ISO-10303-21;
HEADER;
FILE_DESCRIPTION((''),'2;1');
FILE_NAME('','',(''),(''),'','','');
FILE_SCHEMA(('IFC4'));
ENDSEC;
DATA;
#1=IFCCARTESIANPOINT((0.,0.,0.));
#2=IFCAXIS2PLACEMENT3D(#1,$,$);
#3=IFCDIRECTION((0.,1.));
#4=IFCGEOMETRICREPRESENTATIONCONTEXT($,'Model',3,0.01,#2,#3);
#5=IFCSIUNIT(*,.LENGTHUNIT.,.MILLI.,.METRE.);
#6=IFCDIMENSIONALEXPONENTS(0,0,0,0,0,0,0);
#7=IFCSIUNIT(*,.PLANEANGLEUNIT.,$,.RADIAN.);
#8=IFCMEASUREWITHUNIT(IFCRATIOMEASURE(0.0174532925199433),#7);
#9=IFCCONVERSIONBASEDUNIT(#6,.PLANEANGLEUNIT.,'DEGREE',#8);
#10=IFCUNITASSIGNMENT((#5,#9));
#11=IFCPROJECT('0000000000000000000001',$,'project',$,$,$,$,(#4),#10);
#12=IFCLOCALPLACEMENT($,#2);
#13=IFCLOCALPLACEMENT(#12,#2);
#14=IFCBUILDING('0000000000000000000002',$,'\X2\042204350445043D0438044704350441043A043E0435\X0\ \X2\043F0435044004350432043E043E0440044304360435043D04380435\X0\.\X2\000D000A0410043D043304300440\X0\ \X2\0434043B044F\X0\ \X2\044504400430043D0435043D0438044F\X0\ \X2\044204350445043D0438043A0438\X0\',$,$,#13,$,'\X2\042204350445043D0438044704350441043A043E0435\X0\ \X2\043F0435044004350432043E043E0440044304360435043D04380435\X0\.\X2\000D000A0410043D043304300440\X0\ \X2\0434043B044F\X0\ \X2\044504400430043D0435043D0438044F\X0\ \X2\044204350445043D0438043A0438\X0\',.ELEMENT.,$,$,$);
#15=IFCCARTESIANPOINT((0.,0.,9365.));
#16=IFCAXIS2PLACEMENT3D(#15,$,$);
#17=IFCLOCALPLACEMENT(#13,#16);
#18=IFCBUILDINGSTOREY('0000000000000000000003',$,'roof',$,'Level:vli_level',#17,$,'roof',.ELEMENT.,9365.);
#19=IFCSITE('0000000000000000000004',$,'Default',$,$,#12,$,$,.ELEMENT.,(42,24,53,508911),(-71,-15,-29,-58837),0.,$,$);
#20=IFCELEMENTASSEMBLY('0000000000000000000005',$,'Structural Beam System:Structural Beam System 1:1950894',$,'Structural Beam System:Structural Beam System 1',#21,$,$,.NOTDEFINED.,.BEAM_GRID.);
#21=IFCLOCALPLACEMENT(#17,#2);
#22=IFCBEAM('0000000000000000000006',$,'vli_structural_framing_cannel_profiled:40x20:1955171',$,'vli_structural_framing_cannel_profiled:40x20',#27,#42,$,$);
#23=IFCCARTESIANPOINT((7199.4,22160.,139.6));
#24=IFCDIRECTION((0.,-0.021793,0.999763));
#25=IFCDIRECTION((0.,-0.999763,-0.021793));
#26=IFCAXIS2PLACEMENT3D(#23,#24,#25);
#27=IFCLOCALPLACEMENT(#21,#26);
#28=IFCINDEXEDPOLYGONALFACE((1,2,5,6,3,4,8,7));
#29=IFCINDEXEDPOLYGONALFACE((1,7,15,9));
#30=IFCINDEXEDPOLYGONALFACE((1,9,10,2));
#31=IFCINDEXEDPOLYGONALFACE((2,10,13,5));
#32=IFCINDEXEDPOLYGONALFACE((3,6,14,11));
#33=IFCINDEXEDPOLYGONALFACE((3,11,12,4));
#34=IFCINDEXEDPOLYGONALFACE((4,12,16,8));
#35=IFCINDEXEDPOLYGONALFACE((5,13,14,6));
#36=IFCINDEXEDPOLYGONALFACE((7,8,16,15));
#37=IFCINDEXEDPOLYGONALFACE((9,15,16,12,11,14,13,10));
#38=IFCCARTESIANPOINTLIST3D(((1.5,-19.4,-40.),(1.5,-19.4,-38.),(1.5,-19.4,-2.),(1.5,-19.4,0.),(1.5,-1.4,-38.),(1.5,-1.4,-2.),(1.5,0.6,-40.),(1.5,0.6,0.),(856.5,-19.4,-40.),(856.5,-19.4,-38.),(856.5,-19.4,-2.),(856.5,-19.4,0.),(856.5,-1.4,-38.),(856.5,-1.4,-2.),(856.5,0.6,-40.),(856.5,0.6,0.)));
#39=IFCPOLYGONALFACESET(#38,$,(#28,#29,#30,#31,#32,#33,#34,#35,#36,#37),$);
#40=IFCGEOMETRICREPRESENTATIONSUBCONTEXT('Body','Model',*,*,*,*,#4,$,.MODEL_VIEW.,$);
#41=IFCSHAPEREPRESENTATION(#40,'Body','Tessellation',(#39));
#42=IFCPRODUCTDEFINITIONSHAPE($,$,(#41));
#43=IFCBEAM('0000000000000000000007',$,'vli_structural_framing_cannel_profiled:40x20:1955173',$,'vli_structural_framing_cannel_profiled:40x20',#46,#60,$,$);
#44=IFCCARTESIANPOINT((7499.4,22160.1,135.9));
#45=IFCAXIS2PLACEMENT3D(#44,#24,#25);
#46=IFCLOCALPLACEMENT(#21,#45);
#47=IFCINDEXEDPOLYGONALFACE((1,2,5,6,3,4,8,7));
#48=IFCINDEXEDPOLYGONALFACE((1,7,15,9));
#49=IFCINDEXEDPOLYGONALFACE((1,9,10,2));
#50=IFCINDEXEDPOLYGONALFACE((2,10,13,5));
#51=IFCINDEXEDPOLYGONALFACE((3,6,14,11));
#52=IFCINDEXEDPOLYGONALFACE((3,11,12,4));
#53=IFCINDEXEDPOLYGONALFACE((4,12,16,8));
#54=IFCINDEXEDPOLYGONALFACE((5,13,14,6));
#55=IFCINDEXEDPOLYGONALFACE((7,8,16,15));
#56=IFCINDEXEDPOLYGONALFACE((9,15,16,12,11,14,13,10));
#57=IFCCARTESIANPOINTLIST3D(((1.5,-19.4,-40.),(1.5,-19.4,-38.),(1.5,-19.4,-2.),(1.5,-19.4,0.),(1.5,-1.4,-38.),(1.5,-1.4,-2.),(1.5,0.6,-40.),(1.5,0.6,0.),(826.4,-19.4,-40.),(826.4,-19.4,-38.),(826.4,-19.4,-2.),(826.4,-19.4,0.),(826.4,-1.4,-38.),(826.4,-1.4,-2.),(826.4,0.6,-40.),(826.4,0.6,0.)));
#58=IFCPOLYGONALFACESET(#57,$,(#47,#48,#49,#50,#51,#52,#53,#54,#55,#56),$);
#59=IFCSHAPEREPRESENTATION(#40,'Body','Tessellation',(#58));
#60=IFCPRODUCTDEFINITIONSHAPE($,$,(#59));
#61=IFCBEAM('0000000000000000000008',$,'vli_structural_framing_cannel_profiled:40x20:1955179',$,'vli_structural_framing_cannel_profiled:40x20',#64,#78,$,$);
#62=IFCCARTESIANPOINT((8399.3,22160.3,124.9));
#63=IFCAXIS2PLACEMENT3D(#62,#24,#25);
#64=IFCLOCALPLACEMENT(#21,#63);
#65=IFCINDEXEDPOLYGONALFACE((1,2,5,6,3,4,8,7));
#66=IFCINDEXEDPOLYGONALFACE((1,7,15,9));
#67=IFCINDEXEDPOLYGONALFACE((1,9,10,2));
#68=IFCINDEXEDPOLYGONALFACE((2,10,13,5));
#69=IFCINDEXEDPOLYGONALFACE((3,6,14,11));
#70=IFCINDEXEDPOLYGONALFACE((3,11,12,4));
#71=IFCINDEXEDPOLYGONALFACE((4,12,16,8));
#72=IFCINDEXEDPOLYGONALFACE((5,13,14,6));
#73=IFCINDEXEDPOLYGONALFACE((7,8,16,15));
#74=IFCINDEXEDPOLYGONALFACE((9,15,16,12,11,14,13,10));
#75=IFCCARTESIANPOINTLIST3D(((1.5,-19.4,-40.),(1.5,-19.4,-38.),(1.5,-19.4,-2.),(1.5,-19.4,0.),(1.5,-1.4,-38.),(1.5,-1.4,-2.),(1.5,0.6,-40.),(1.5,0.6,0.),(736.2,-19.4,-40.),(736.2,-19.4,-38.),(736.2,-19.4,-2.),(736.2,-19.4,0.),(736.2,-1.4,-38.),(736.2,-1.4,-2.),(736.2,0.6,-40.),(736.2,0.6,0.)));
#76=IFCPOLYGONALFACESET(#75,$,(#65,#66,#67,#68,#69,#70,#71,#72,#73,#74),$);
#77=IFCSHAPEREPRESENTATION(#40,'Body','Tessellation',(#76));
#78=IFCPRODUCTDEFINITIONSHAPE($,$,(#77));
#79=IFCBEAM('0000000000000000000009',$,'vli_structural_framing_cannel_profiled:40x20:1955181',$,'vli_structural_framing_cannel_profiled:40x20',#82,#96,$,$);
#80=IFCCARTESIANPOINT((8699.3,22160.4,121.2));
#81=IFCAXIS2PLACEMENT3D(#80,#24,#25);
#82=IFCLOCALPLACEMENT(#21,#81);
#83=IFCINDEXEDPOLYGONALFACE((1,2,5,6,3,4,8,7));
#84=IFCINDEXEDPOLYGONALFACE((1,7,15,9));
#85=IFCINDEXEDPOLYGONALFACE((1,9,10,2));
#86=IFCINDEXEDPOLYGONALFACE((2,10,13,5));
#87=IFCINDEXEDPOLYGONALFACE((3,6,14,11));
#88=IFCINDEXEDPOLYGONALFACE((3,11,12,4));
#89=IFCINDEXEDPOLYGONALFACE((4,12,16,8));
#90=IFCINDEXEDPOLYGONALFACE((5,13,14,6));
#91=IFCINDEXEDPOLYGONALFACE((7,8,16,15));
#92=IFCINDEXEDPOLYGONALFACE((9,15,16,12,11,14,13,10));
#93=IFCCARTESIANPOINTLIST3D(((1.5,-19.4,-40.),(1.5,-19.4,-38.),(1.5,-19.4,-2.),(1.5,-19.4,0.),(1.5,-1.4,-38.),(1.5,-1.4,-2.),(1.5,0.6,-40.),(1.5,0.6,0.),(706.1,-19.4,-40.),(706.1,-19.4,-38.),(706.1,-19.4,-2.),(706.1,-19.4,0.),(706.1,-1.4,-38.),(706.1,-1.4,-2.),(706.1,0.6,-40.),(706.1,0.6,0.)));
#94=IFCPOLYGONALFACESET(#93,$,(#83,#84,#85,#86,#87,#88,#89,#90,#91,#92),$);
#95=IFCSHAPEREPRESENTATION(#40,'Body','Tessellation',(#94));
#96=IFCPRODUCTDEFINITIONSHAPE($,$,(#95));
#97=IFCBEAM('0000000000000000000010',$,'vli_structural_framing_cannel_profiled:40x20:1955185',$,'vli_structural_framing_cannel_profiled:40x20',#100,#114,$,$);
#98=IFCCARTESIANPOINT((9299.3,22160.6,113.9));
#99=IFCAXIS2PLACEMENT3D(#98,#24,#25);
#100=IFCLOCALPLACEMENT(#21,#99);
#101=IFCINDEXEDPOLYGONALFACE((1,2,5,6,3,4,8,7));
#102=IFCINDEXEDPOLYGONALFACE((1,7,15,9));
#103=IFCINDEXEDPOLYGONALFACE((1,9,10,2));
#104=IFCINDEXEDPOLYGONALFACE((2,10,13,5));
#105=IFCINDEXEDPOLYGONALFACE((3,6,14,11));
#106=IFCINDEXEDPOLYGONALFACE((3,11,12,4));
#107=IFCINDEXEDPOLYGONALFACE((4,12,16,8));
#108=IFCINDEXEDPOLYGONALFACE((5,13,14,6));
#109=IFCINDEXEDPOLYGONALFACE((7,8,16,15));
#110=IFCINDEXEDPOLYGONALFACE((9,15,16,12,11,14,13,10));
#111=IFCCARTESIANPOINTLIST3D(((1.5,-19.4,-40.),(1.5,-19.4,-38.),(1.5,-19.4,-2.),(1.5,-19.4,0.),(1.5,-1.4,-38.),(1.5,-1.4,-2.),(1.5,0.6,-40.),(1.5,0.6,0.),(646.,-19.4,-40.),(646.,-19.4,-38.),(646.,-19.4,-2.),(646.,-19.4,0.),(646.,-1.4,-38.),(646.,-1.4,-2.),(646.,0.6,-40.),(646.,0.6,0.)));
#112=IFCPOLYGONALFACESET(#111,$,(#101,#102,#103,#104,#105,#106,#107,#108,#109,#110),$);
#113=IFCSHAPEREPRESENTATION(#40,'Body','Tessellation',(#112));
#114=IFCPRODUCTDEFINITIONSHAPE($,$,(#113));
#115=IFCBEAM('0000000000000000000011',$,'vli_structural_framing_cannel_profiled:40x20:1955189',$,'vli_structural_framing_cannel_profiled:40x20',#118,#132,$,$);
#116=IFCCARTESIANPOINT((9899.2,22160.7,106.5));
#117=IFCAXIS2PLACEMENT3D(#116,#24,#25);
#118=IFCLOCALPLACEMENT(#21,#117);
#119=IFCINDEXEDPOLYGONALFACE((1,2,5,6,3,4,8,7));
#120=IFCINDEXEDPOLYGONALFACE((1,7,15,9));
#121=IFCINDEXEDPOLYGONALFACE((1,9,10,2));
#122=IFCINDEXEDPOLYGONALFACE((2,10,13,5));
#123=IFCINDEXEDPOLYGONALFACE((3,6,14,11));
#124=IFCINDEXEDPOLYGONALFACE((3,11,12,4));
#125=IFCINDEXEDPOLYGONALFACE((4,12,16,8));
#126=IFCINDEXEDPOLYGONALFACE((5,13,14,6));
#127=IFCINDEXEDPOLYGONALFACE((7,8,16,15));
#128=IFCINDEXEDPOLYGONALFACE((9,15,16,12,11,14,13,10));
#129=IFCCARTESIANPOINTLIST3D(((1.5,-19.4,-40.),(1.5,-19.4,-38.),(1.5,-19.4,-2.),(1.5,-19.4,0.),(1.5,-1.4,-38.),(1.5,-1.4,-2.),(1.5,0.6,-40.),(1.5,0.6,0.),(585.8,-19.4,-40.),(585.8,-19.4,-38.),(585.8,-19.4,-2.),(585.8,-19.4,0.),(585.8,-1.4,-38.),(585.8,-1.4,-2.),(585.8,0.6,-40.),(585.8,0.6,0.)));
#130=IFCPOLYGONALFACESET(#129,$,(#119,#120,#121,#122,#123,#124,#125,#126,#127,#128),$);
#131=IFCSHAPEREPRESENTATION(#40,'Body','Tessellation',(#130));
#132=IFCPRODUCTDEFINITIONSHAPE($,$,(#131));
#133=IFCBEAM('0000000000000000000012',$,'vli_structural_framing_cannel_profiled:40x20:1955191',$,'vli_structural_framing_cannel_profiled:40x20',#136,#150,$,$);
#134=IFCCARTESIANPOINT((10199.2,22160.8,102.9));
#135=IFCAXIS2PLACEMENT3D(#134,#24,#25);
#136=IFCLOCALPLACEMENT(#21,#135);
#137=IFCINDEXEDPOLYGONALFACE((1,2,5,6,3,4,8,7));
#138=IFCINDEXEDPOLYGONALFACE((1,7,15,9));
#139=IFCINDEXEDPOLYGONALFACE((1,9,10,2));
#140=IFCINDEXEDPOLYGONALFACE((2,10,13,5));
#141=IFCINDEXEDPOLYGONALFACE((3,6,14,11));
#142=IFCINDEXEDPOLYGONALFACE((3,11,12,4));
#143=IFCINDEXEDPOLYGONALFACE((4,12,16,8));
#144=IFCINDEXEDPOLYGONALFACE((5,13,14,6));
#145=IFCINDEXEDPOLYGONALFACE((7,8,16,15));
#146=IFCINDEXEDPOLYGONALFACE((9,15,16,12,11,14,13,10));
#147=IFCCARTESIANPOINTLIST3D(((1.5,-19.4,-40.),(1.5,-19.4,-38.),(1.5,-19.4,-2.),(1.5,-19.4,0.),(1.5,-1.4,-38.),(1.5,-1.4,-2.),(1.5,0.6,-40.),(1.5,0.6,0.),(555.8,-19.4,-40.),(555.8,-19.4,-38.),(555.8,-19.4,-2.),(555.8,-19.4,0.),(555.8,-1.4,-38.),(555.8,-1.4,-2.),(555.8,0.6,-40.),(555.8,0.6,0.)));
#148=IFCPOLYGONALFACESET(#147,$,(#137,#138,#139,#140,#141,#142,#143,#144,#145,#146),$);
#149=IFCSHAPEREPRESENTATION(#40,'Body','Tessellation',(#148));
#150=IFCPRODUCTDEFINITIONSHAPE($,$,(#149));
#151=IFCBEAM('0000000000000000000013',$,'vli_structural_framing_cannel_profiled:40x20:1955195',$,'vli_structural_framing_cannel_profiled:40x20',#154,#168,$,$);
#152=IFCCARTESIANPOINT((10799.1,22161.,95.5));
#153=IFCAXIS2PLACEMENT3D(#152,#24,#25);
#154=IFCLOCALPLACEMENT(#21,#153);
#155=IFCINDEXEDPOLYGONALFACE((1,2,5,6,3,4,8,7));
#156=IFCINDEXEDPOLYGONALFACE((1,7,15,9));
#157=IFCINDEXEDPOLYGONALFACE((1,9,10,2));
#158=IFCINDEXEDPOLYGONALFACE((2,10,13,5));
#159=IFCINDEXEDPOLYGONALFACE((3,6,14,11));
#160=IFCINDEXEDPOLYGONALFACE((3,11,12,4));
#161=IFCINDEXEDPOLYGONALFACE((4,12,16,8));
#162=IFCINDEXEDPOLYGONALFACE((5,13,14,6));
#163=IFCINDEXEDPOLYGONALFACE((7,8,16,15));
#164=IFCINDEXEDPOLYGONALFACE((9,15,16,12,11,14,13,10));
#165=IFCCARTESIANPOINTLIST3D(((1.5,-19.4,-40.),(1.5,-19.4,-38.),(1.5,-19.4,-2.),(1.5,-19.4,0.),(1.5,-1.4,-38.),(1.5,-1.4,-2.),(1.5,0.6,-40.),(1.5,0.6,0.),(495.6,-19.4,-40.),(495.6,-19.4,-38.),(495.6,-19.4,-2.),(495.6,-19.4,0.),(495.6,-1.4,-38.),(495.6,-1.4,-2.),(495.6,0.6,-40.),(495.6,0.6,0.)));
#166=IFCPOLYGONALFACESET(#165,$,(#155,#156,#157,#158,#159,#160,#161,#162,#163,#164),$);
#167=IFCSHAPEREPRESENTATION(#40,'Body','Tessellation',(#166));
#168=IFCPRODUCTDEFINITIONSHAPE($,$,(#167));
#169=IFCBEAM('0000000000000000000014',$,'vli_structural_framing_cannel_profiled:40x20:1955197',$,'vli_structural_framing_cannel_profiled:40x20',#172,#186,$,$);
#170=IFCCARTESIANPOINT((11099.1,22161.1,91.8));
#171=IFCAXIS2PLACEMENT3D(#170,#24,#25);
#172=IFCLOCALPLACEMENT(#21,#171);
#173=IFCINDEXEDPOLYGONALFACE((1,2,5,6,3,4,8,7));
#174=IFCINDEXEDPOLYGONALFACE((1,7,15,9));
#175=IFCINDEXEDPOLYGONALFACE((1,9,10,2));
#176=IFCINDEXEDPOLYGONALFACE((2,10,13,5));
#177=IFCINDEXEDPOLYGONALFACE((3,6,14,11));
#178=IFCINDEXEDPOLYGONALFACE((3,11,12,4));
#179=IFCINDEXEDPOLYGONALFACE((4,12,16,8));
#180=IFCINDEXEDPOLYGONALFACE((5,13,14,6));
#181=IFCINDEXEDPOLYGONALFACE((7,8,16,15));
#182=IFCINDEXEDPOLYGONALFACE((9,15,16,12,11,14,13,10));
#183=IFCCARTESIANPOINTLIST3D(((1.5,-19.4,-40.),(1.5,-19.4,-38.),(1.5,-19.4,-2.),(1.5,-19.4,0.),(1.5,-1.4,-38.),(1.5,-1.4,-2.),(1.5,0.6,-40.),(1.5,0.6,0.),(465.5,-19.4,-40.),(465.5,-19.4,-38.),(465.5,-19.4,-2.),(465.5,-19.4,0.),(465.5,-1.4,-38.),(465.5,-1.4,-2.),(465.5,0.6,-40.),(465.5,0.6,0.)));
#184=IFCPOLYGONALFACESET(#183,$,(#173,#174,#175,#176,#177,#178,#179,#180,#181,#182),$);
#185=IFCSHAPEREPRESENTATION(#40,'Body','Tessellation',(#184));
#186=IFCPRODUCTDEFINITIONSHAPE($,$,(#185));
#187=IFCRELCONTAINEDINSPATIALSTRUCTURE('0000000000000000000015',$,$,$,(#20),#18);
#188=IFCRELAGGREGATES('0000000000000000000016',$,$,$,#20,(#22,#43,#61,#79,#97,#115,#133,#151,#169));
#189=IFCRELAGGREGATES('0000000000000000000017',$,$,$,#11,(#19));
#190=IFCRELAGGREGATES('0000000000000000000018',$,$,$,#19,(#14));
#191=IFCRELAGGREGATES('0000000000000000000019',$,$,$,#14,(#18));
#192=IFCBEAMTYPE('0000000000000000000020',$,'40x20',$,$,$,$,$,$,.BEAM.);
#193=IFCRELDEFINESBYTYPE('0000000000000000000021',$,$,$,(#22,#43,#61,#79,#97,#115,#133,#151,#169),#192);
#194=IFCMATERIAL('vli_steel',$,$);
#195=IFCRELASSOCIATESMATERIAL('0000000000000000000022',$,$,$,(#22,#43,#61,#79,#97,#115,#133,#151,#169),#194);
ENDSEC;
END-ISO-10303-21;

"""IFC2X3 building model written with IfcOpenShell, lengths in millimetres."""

from ifc_helpers import new_model, entity, si_unit, converted_unit, direction, frame, origin, place, context, subcontext, project, spatial, polyline, outline, extrude, material, type_object, element, aggregate, save


model = new_model("IFC2X3")

# Units and contexts
model_context = context("Model", 3, precision=0.01, world=origin(), true_north=direction((0.0, 1.0)))
body_context = subcontext(model_context, "Body", "Model", "MODEL_VIEW")
ifc_project = project(units=[si_unit("LENGTHUNIT", "METRE", prefix="MILLI"), converted_unit("PLANEANGLEUNIT", "DEGREE", entity("IfcRatioMeasure", 0.0174532925199433), si_unit("PLANEANGLEUNIT", "RADIAN"), dimensions=[0, 0, 0, 0, 0, 0, 0])], contexts=[model_context])

# Site, building, storey
site_placement = place(None, origin())
site = spatial("IfcSite", under=ifc_project, at=site_placement, Name="Default", CompositionType="ELEMENT", RefLatitude=(42, 24, 53, 508911), RefLongitude=(-71, -15, -29, -58837), RefElevation=0.0)
building_placement = place(site_placement, origin())
building = spatial("IfcBuilding", under=site, at=building_placement, Name="Техническое перевооружение.\r\nАнгар для хранения техники", LongName="Техническое перевооружение.\r\nАнгар для хранения техники", CompositionType="ELEMENT")
storey_placement = place(building_placement, frame((0.0, 0.0, 9365.0)))
storey = spatial("IfcBuildingStorey", under=building, at=storey_placement, Name="roof", ObjectType="Level:vli_level", LongName="roof", CompositionType="ELEMENT", Elevation=9365.0)

# Element assembly, beams
ifc_material = material(Name="vli_steel")
beam_type = type_object("IfcBeamType", Name="40x20", PredefinedType="BEAM")
assembly_1_placement = place(storey_placement, origin())
assembly_1 = element("IfcElementAssembly", 1, at=assembly_1_placement, inside=storey, Name="Structural Beam System:Structural Beam System 1:1950894", ObjectType="Structural Beam System:Structural Beam System 1", AssemblyPlace="NOTDEFINED", PredefinedType="BEAM_GRID")
beam_1_placement = place(assembly_1_placement, frame((7199.4, 22160.0, 139.6), z_axis=(0.0, -0.021793, 0.999763), x_axis=(0.0, -0.999763, -0.021793)))
beam_1 = element("IfcBeam", 2, at=beam_1_placement, type_object=beam_type, material=ifc_material, Name="vli_structural_framing_cannel_profiled:40x20:1955171", ObjectType="vli_structural_framing_cannel_profiled:40x20", context=body_context, shape_type="SweptSolid", body=[
    extrude(outline(polyline([(-20.0, -9.5), (-18.0, -9.5), (-18.0, 8.5), (18.0, 8.5), (18.0, -9.5), (20.0, -9.5), (20.0, 10.5), (-20.0, 10.5), (-20.0, -9.5)])), frame((1.5, -9.9, -20.0), z_axis=(1.0, 0.0, 0.0), x_axis=(0.0, 0.0, -1.0)), (0.0, 0.0, 1.0), 855.0),
])
beam_2_placement = place(assembly_1_placement, frame((7499.4, 22160.1, 135.9), z_axis=(0.0, -0.021793, 0.999763), x_axis=(0.0, -0.999763, -0.021793)))
beam_2 = element("IfcBeam", 3, at=beam_2_placement, type_object=beam_type, material=ifc_material, Name="vli_structural_framing_cannel_profiled:40x20:1955173", ObjectType="vli_structural_framing_cannel_profiled:40x20", context=body_context, shape_type="SweptSolid", body=[
    extrude(outline(polyline([(-20.0, -9.5), (-18.0, -9.5), (-18.0, 8.5), (18.0, 8.5), (18.0, -9.5), (20.0, -9.5), (20.0, 10.5), (-20.0, 10.5), (-20.0, -9.5)])), frame((1.5, -9.9, -20.0), z_axis=(1.0, 0.0, 0.0), x_axis=(0.0, 0.0, -1.0)), (0.0, 0.0, 1.0), 825.0),
])
beam_3_placement = place(assembly_1_placement, frame((8399.3, 22160.3, 124.9), z_axis=(0.0, -0.021793, 0.999763), x_axis=(0.0, -0.999763, -0.021793)))
beam_3 = element("IfcBeam", 4, at=beam_3_placement, type_object=beam_type, material=ifc_material, Name="vli_structural_framing_cannel_profiled:40x20:1955179", ObjectType="vli_structural_framing_cannel_profiled:40x20", context=body_context, shape_type="SweptSolid", body=[
    extrude(outline(polyline([(-20.0, -9.5), (-18.0, -9.5), (-18.0, 8.5), (18.0, 8.5), (18.0, -9.5), (20.0, -9.5), (20.0, 10.5), (-20.0, 10.5), (-20.0, -9.5)])), frame((1.5, -9.9, -20.0), z_axis=(1.0, 0.0, 0.0), x_axis=(0.0, 0.0, -1.0)), (0.0, 0.0, 1.0), 734.7),
])
beam_4_placement = place(assembly_1_placement, frame((8699.3, 22160.4, 121.2), z_axis=(0.0, -0.021793, 0.999763), x_axis=(0.0, -0.999763, -0.021793)))
beam_4 = element("IfcBeam", 5, at=beam_4_placement, type_object=beam_type, material=ifc_material, Name="vli_structural_framing_cannel_profiled:40x20:1955181", ObjectType="vli_structural_framing_cannel_profiled:40x20", context=body_context, shape_type="SweptSolid", body=[
    extrude(outline(polyline([(-20.0, -9.5), (-18.0, -9.5), (-18.0, 8.5), (18.0, 8.5), (18.0, -9.5), (20.0, -9.5), (20.0, 10.5), (-20.0, 10.5), (-20.0, -9.5)])), frame((1.5, -9.9, -20.0), z_axis=(1.0, 0.0, 0.0), x_axis=(0.0, 0.0, -1.0)), (0.0, 0.0, 1.0), 704.7),
])
beam_5_placement = place(assembly_1_placement, frame((9299.3, 22160.6, 113.9), z_axis=(0.0, -0.021793, 0.999763), x_axis=(0.0, -0.999763, -0.021793)))
beam_5 = element("IfcBeam", 6, at=beam_5_placement, type_object=beam_type, material=ifc_material, Name="vli_structural_framing_cannel_profiled:40x20:1955185", ObjectType="vli_structural_framing_cannel_profiled:40x20", context=body_context, shape_type="SweptSolid", body=[
    extrude(outline(polyline([(-20.0, -9.5), (-18.0, -9.5), (-18.0, 8.5), (18.0, 8.5), (18.0, -9.5), (20.0, -9.5), (20.0, 10.5), (-20.0, 10.5), (-20.0, -9.5)])), frame((1.5, -9.9, -20.0), z_axis=(1.0, 0.0, 0.0), x_axis=(0.0, 0.0, -1.0)), (0.0, 0.0, 1.0), 644.5),
])
beam_6_placement = place(assembly_1_placement, frame((9899.2, 22160.7, 106.5), z_axis=(0.0, -0.021793, 0.999763), x_axis=(0.0, -0.999763, -0.021793)))
beam_6 = element("IfcBeam", 7, at=beam_6_placement, type_object=beam_type, material=ifc_material, Name="vli_structural_framing_cannel_profiled:40x20:1955189", ObjectType="vli_structural_framing_cannel_profiled:40x20", context=body_context, shape_type="SweptSolid", body=[
    extrude(outline(polyline([(-20.0, -9.5), (-18.0, -9.5), (-18.0, 8.5), (18.0, 8.5), (18.0, -9.5), (20.0, -9.5), (20.0, 10.5), (-20.0, 10.5), (-20.0, -9.5)])), frame((1.5, -9.9, -20.0), z_axis=(1.0, 0.0, 0.0), x_axis=(0.0, 0.0, -1.0)), (0.0, 0.0, 1.0), 584.4),
])
beam_7_placement = place(assembly_1_placement, frame((10199.2, 22160.8, 102.9), z_axis=(0.0, -0.021793, 0.999763), x_axis=(0.0, -0.999763, -0.021793)))
beam_7 = element("IfcBeam", 8, at=beam_7_placement, type_object=beam_type, material=ifc_material, Name="vli_structural_framing_cannel_profiled:40x20:1955191", ObjectType="vli_structural_framing_cannel_profiled:40x20", context=body_context, shape_type="SweptSolid", body=[
    extrude(outline(polyline([(-20.0, -9.5), (-18.0, -9.5), (-18.0, 8.5), (18.0, 8.5), (18.0, -9.5), (20.0, -9.5), (20.0, 10.5), (-20.0, 10.5), (-20.0, -9.5)])), frame((1.5, -9.9, -20.0), z_axis=(1.0, 0.0, 0.0), x_axis=(0.0, 0.0, -1.0)), (0.0, 0.0, 1.0), 554.3),
])
beam_8_placement = place(assembly_1_placement, frame((10799.1, 22161.0, 95.5), z_axis=(0.0, -0.021793, 0.999763), x_axis=(0.0, -0.999763, -0.021793)))
beam_8 = element("IfcBeam", 9, at=beam_8_placement, type_object=beam_type, material=ifc_material, Name="vli_structural_framing_cannel_profiled:40x20:1955195", ObjectType="vli_structural_framing_cannel_profiled:40x20", context=body_context, shape_type="SweptSolid", body=[
    extrude(outline(polyline([(-20.0, -9.5), (-18.0, -9.5), (-18.0, 8.5), (18.0, 8.5), (18.0, -9.5), (20.0, -9.5), (20.0, 10.5), (-20.0, 10.5), (-20.0, -9.5)])), frame((1.5, -9.9, -20.0), z_axis=(1.0, 0.0, 0.0), x_axis=(0.0, 0.0, -1.0)), (0.0, 0.0, 1.0), 494.1),
])
beam_9_placement = place(assembly_1_placement, frame((11099.1, 22161.1, 91.8), z_axis=(0.0, -0.021793, 0.999763), x_axis=(0.0, -0.999763, -0.021793)))
beam_9 = element("IfcBeam", 10, at=beam_9_placement, type_object=beam_type, material=ifc_material, Name="vli_structural_framing_cannel_profiled:40x20:1955197", ObjectType="vli_structural_framing_cannel_profiled:40x20", context=body_context, shape_type="SweptSolid", body=[
    extrude(outline(polyline([(-20.0, -9.5), (-18.0, -9.5), (-18.0, 8.5), (18.0, 8.5), (18.0, -9.5), (20.0, -9.5), (20.0, 10.5), (-20.0, 10.5), (-20.0, -9.5)])), frame((1.5, -9.9, -20.0), z_axis=(1.0, 0.0, 0.0), x_axis=(0.0, 0.0, -1.0)), (0.0, 0.0, 1.0), 464.1),
])

aggregate(assembly_1, [beam_1, beam_2, beam_3, beam_4, beam_5, beam_6, beam_7, beam_8, beam_9])

save(model, "model.ifc")
